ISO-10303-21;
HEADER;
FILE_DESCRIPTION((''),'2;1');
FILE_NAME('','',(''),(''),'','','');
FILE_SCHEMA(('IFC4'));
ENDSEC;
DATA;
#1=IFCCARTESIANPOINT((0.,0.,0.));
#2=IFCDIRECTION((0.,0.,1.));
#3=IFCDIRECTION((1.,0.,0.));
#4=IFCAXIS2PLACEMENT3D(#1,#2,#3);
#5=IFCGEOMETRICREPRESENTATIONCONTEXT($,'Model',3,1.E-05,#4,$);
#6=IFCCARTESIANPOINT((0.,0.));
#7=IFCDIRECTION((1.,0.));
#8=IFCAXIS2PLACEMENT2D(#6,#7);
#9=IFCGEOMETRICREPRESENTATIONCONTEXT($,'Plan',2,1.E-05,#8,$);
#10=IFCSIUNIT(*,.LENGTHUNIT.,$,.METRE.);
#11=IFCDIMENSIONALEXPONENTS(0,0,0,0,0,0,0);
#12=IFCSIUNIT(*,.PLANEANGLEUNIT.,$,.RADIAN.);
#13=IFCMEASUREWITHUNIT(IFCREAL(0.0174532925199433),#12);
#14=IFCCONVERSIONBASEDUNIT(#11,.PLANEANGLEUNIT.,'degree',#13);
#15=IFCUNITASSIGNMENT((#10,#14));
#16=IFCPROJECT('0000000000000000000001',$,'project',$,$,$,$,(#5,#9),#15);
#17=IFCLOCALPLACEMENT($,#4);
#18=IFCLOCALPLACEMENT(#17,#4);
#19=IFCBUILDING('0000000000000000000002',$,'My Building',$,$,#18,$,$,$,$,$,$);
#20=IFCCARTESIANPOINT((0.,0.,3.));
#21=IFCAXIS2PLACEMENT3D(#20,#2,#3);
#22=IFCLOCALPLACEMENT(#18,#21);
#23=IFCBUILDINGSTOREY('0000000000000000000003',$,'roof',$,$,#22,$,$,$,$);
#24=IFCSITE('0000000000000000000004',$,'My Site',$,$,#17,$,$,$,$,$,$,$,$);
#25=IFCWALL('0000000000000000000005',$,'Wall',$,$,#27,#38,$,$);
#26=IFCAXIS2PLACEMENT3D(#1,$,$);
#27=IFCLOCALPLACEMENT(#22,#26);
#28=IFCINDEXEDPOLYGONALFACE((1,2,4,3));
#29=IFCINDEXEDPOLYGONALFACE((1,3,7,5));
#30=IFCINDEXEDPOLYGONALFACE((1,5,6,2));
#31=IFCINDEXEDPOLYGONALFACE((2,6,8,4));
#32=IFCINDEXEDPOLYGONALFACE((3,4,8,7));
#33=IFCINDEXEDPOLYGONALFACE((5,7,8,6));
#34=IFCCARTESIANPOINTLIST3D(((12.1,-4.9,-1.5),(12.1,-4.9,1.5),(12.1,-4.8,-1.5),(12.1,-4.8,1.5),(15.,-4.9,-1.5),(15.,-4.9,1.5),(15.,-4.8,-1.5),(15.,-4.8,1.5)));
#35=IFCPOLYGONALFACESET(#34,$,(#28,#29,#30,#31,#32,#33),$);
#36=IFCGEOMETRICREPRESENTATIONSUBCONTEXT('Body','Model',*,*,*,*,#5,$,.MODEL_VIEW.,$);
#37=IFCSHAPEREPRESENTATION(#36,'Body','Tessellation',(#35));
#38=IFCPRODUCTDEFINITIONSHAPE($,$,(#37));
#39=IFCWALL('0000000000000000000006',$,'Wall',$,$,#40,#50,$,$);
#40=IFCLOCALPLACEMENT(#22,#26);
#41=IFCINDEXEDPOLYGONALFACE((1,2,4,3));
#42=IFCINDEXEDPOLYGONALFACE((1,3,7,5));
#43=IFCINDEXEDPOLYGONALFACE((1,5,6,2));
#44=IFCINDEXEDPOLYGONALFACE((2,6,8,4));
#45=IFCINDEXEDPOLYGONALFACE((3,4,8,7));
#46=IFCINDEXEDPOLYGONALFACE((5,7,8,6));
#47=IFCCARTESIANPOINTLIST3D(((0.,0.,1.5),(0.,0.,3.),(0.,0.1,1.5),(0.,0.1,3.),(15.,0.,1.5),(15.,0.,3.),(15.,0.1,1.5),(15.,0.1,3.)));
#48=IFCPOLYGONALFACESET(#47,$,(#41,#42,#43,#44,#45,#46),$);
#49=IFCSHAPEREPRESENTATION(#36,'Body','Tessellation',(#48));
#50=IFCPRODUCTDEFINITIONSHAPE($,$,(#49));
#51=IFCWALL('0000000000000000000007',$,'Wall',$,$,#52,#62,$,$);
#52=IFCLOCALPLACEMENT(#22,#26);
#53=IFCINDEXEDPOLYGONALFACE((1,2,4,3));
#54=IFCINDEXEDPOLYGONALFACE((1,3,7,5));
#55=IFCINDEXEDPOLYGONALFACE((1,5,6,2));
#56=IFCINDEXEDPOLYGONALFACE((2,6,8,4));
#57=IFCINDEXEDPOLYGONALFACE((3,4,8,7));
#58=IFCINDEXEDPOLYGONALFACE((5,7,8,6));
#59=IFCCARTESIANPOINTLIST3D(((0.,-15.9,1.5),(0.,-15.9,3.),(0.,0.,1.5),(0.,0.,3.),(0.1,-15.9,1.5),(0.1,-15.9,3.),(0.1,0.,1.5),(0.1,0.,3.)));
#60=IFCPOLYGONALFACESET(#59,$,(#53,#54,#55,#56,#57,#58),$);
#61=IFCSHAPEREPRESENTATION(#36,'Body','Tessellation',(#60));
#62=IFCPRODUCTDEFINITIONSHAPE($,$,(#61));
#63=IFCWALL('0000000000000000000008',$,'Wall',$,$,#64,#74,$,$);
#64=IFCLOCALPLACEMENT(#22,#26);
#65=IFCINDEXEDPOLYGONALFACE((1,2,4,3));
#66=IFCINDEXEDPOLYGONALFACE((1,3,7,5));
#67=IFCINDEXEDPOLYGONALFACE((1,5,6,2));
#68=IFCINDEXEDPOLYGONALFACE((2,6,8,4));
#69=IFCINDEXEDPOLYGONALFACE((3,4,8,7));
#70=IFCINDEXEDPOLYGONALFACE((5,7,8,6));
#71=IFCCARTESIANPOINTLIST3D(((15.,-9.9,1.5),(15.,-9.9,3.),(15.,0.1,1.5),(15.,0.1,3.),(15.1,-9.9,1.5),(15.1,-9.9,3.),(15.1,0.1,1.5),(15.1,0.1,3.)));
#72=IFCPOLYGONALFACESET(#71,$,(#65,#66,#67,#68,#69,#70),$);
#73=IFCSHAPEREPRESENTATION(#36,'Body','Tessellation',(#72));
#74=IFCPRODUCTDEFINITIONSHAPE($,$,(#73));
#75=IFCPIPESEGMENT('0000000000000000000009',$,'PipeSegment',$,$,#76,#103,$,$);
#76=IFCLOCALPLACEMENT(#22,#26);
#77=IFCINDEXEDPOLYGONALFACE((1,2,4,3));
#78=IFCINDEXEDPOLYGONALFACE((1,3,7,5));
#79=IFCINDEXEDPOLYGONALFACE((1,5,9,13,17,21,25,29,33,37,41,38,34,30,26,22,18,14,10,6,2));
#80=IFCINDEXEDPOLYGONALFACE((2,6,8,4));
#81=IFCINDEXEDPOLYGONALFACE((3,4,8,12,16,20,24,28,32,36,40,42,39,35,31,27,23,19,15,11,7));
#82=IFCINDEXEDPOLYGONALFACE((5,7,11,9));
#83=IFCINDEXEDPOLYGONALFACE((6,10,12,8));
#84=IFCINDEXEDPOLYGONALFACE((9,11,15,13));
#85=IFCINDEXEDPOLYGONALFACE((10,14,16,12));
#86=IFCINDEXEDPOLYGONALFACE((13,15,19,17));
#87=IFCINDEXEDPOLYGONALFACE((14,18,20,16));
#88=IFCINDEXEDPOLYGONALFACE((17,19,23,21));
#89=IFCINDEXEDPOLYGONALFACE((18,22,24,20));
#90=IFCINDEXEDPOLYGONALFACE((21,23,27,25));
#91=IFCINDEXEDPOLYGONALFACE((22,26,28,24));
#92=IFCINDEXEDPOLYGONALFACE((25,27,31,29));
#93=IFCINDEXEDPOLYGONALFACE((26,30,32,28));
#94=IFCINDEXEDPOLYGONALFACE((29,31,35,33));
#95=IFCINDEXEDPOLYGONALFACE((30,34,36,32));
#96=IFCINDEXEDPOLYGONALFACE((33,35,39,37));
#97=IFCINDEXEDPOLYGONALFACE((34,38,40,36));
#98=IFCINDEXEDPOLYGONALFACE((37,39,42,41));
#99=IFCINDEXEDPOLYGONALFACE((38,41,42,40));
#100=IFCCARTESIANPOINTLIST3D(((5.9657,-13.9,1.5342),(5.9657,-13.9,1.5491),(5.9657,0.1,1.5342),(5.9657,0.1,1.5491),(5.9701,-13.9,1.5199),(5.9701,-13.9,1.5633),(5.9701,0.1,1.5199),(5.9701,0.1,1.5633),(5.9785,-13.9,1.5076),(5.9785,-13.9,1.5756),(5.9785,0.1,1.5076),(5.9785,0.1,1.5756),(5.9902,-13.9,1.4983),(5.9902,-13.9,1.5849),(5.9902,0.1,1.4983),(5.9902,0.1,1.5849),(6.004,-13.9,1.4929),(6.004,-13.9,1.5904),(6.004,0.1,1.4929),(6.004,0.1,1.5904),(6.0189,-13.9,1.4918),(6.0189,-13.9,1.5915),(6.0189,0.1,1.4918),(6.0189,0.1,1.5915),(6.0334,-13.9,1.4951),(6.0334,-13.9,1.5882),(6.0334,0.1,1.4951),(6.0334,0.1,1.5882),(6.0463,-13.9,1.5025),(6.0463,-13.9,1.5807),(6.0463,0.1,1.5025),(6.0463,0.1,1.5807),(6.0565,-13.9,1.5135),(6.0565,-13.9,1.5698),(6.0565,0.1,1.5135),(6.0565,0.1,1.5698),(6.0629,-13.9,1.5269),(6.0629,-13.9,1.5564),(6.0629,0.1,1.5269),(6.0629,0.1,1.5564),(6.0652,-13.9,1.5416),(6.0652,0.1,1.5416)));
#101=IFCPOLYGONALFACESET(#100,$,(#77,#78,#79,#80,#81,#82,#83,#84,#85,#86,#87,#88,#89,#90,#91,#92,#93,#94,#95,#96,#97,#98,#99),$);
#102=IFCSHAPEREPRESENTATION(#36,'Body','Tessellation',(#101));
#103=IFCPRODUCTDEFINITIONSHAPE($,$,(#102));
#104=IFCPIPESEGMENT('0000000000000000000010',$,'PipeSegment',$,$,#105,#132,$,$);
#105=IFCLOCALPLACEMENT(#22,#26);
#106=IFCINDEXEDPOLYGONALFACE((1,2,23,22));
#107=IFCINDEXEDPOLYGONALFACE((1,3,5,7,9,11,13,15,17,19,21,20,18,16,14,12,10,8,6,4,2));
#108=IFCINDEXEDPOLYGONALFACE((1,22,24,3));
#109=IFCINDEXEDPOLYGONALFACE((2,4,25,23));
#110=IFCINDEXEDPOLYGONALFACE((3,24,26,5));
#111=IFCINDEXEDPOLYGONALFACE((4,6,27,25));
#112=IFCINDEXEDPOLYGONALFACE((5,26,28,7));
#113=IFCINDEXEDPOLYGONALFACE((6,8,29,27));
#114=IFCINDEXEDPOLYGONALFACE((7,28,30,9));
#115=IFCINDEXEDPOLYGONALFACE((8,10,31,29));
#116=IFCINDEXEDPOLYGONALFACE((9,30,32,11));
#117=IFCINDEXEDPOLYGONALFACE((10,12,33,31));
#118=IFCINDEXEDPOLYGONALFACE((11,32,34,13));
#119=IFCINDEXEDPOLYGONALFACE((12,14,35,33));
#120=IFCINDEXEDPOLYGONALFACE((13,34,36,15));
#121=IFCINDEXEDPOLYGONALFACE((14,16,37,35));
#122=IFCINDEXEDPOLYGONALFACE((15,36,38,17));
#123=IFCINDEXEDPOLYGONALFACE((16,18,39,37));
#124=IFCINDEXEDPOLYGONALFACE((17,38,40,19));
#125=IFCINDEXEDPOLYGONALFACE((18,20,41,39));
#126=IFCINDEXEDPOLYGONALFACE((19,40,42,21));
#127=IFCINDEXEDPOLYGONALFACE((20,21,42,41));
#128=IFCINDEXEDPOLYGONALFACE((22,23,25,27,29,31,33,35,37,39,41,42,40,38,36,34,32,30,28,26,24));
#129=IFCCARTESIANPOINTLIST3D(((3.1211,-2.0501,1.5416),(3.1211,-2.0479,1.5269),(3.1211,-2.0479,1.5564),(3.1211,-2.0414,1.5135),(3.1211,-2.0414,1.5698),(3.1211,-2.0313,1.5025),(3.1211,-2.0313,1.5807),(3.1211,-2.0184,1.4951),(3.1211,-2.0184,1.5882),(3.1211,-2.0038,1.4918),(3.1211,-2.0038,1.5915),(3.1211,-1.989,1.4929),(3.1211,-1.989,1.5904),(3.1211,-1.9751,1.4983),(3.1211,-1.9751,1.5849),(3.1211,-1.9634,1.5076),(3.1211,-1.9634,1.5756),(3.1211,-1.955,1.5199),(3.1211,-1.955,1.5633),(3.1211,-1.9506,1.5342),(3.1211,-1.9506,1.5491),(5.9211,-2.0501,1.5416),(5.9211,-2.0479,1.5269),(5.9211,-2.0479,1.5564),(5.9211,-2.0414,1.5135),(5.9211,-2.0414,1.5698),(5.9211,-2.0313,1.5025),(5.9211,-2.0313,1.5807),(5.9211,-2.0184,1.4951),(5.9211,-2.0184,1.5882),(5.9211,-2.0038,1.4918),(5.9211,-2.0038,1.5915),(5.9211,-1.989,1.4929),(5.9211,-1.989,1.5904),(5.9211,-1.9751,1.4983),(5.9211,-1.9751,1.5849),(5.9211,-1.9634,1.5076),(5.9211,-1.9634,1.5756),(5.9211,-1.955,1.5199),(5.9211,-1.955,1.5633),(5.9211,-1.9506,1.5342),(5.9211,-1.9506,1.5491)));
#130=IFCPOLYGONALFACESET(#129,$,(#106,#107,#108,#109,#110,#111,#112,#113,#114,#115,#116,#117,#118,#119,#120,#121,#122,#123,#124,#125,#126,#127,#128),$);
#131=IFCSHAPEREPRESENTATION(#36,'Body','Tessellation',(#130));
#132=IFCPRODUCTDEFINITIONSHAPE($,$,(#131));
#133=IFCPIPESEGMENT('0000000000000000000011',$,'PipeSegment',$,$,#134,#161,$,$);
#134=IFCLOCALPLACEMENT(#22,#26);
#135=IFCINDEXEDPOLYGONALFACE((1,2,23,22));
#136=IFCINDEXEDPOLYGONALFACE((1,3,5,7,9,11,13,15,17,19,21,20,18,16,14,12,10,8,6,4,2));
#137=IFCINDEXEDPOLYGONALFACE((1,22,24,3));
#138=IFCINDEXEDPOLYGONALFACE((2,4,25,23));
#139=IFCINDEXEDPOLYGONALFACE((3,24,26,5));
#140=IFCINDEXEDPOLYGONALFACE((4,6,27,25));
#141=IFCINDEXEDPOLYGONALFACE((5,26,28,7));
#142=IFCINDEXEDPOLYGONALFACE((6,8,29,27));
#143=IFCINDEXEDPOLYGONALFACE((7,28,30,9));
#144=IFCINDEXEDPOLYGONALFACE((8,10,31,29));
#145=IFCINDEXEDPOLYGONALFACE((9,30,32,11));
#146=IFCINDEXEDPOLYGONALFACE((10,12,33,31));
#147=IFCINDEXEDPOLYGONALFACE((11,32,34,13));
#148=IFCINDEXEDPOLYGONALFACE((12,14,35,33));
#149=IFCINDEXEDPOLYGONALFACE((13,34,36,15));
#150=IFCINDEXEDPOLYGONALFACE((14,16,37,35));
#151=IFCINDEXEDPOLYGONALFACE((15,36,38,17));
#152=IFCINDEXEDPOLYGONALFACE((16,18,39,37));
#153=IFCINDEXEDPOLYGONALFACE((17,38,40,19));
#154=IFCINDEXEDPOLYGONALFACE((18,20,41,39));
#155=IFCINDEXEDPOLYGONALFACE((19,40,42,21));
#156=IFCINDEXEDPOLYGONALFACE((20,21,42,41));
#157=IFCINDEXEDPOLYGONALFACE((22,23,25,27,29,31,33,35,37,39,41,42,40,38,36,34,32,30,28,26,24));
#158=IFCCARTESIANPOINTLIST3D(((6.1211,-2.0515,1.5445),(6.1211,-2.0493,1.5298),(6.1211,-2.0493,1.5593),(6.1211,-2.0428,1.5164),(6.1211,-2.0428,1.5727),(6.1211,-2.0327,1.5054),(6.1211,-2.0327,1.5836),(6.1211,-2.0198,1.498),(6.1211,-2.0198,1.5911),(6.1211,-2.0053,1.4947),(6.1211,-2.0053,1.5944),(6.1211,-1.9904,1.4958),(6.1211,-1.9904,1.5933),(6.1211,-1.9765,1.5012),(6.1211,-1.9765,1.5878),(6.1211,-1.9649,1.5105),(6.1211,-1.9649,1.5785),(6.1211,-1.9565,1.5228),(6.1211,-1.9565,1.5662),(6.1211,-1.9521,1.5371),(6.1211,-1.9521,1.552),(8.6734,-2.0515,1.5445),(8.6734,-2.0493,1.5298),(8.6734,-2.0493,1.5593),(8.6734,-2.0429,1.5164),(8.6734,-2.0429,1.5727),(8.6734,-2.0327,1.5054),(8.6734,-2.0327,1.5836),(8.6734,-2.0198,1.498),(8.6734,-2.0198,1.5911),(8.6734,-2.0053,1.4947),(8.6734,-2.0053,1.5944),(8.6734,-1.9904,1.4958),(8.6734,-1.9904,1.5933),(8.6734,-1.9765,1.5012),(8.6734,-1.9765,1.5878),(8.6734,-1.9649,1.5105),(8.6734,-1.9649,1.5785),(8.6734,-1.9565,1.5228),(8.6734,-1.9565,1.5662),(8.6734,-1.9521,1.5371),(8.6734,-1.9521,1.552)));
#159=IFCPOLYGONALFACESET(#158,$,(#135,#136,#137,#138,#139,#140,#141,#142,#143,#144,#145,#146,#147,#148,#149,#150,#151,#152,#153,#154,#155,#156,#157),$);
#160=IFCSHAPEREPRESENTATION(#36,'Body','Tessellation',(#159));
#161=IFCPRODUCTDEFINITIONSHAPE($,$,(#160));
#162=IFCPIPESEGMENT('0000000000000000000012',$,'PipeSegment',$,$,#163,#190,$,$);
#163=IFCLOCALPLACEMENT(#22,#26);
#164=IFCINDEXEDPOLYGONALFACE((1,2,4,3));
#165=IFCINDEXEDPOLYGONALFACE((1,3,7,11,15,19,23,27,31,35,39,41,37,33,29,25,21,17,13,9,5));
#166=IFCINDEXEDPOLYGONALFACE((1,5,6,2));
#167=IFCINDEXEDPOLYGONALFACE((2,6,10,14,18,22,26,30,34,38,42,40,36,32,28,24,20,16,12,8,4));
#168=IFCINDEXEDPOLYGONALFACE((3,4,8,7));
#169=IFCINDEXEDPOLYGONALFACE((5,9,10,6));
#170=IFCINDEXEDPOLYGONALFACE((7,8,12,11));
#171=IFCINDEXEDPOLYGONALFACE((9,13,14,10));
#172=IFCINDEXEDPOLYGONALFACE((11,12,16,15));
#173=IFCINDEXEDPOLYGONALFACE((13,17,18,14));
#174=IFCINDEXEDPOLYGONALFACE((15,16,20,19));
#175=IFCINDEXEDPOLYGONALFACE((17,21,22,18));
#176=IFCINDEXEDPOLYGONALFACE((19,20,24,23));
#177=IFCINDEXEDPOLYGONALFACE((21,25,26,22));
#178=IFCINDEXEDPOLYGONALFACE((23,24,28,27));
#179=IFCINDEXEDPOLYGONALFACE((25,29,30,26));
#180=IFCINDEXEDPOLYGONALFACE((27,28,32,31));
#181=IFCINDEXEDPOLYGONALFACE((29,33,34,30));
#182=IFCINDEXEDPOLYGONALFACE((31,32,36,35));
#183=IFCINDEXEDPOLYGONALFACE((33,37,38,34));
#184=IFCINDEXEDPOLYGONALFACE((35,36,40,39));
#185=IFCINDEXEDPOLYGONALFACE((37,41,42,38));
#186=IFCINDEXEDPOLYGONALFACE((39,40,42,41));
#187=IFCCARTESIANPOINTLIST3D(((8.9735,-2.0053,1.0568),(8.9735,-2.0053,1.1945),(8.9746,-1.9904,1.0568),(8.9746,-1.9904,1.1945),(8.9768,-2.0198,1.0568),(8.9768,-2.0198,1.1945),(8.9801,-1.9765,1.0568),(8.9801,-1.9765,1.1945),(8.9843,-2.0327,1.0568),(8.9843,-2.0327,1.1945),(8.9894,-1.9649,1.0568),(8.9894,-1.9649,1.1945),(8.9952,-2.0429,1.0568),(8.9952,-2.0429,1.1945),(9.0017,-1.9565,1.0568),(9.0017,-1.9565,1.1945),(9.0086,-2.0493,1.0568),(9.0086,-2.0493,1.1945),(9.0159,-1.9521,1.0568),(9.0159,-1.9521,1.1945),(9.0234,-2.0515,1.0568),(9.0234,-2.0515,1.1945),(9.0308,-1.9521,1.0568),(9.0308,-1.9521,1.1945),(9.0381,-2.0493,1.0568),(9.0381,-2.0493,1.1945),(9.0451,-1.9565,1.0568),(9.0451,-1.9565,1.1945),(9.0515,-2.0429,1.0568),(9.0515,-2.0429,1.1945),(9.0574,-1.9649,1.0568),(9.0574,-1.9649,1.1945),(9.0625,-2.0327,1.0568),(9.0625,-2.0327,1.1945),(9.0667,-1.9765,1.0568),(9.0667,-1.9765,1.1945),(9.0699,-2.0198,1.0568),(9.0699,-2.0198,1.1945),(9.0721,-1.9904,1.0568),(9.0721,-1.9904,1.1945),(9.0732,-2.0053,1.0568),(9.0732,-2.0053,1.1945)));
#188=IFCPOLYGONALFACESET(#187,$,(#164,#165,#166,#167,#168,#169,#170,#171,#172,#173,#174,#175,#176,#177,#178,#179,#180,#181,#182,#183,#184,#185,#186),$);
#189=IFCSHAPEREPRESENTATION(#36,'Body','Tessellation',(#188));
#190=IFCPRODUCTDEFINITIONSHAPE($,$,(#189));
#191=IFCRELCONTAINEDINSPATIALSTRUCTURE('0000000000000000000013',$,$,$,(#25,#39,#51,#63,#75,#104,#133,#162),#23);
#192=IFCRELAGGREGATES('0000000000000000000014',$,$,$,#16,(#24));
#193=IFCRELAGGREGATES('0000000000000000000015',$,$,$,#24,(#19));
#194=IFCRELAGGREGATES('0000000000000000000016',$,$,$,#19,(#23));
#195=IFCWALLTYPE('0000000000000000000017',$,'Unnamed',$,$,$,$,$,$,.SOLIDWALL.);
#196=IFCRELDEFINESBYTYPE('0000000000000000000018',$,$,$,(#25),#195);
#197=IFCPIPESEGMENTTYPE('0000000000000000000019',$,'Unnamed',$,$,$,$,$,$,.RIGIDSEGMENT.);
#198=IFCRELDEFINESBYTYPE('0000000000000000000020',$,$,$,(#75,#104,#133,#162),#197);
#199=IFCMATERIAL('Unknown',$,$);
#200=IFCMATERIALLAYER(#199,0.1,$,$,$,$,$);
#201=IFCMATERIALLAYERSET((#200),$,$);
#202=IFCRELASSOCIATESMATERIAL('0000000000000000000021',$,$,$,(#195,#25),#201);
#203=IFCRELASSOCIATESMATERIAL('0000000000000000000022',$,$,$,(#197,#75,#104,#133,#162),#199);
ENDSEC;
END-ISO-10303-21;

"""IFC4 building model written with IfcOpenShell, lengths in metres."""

from ifc_helpers import new_model, entity, si_unit, converted_unit, frame, origin_with_axes, origin_2d_with_axis, place, context, subcontext, project, spatial, line, indexed_curve, circle, outline, extrude, material, layer, layer_set, layer_usage, material_profile, profile_set, profile_usage, type_object, element, save


model = new_model("IFC4")

# Units and contexts
model_context = context("Model", 3, precision=1e-05, world=origin_with_axes())
plan_context = context("Plan", 2, precision=1e-05, world=origin_2d_with_axis())
body_context = subcontext(model_context, "Body", "Model", "MODEL_VIEW")
ifc_project = project(units=[si_unit("LENGTHUNIT", "METRE"), converted_unit("PLANEANGLEUNIT", "degree", entity("IfcReal", 0.0174532925199433), si_unit("PLANEANGLEUNIT", "RADIAN"), dimensions=[0, 0, 0, 0, 0, 0, 0])], contexts=[model_context, plan_context])

# Site, building, storey
site_placement = place(None, origin_with_axes())
site = spatial("IfcSite", under=ifc_project, at=site_placement, Name="My Site")
building_placement = place(site_placement, origin_with_axes())
building = spatial("IfcBuilding", under=site, at=building_placement, Name="My Building")
storey_placement = place(building_placement, frame((0.0, 0.0, 3.0), z_axis=(0.0, 0.0, 1.0), x_axis=(1.0, 0.0, 0.0)))
storey = spatial("IfcBuildingStorey", under=building, at=storey_placement, Name="roof")

# Walls
ifc_material = material(Name="Unknown")
ifc_layer = layer(ifc_material, 0.1)
ifc_layer_set = layer_set([ifc_layer])
ifc_layer_usage = layer_usage(ifc_layer_set, "AXIS2", "POSITIVE", 0.0)
wall_type = type_object("IfcWallType", Name="Unnamed", PredefinedType="SOLIDWALL", material=ifc_layer_set)
wall_1_placement = place(storey_placement, frame((12.1, -4.9, -1.5), z_axis=(0.0, 0.0, 1.0), x_axis=(1.0, 0.0, 0.0)))
element("IfcWall", 1, at=wall_1_placement, inside=storey, type_object=wall_type, material=ifc_layer_usage, Name="Wall", context=body_context, shape_type="SweptSolid", body=[
    extrude(outline(indexed_curve([(0.0, 0.0), (0.0, 0.1), (2.9, 0.1), (2.9, 0.0)], segments=[line(1, 2, 3, 4, 1)])), origin_with_axes(), (0.0, 0.0, 1.0), 3.0),
])
wall_2_placement = place(storey_placement, frame((0.0, 0.0, 1.5), z_axis=(0.0, 0.0, 1.0), x_axis=(1.0, 0.0, 0.0)))
element("IfcWall", 2, at=wall_2_placement, inside=storey, Name="Wall", context=body_context, shape_type="SweptSolid", body=[
    extrude(outline(indexed_curve([(0.0, 0.0), (0.0, 0.1), (15.0, 0.1), (15.0, 0.0)], segments=[line(1, 2, 3, 4, 1)])), origin_with_axes(), (0.0, 0.0, 1.0), 1.5),
])
wall_3_placement = place(storey_placement, frame((0.0, 0.0, 1.5), z_axis=(0.0, 0.0, 1.0), x_axis=(0.0, -1.0, 0.0)))
element("IfcWall", 3, at=wall_3_placement, inside=storey, Name="Wall", context=body_context, shape_type="SweptSolid", body=[
    extrude(outline(indexed_curve([(0.0, 0.0), (0.0, 0.1), (15.9, 0.1), (15.9, 0.0)], segments=[line(1, 2, 3, 4, 1)])), origin_with_axes(), (0.0, 0.0, 1.0), 1.5),
])
wall_4_placement = place(storey_placement, frame((15.0, 0.1, 1.5), z_axis=(0.0, 0.0, 1.0), x_axis=(0.0, -1.0, 0.0)))
element("IfcWall", 4, at=wall_4_placement, inside=storey, Name="Wall", context=body_context, shape_type="SweptSolid", body=[
    extrude(outline(indexed_curve([(0.0, 0.0), (0.0, 0.1), (10.0, 0.1), (10.0, 0.0)], segments=[line(1, 2, 3, 4, 1)])), origin_with_axes(), (0.0, 0.0, 1.0), 1.5),
])

# Pipe segments
ifc_material_profile_1 = material_profile(ifc_material, circle(Radius=0.05))
ifc_profile_set_1 = profile_set([ifc_material_profile_1])
ifc_profile_usage_1 = profile_usage(ifc_profile_set_1, cardinal=5)
pipe_segment_type = type_object("IfcPipeSegmentType", Name="Unnamed", PredefinedType="RIGIDSEGMENT", material=ifc_profile_set_1)
pipe_segment_1_placement = place(storey_placement, frame((6.0152, 0.1, 1.5416), z_axis=(0.0, -1.0, 0.0), x_axis=(1.0, 0.0, 0.0)))
element("IfcPipeSegment", 5, at=pipe_segment_1_placement, inside=storey, type_object=pipe_segment_type, material=ifc_profile_usage_1, Name="PipeSegment", context=body_context, shape_type="SweptSolid", body=[
    extrude(circle(Radius=0.05), origin_with_axes(), (0.0, 0.0, 1.0), 14.0),
])
ifc_profile_usage_2 = profile_usage(ifc_profile_set_1, cardinal=5)
pipe_segment_2_placement = place(storey_placement, frame((5.9211, -2.0001, 1.5416), z_axis=(-1.0, 0.0, 0.0), x_axis=(0.0, -1.0, 0.0)))
element("IfcPipeSegment", 6, at=pipe_segment_2_placement, inside=storey, type_object=pipe_segment_type, material=ifc_profile_usage_2, Name="PipeSegment", context=body_context, shape_type="SweptSolid", body=[
    extrude(circle(Radius=0.05), origin_with_axes(), (0.0, 0.0, 1.0), 2.8),
])
ifc_profile_usage_3 = profile_usage(ifc_profile_set_1, cardinal=5)
pipe_segment_3_placement = place(storey_placement, frame((6.1211, -2.0015, 1.5445), z_axis=(1.0, 0.0, 0.0), x_axis=(0.0, -1.0, 0.0)))
element("IfcPipeSegment", 7, at=pipe_segment_3_placement, inside=storey, type_object=pipe_segment_type, material=ifc_profile_usage_3, Name="PipeSegment", context=body_context, shape_type="SweptSolid", body=[
    extrude(circle(Radius=0.05), origin_with_axes(), (0.0, 0.0, 1.0), 2.5523),
])
ifc_profile_usage_4 = profile_usage(ifc_profile_set_1, cardinal=5)
pipe_segment_4_placement = place(storey_placement, frame((9.0234, -2.0015, 1.0568), z_axis=(0.000001, -0.000001, 1.0), x_axis=(0.0, -1.0, -0.000001)))
element("IfcPipeSegment", 8, at=pipe_segment_4_placement, inside=storey, type_object=pipe_segment_type, material=ifc_profile_usage_4, Name="PipeSegment", context=body_context, shape_type="SweptSolid", body=[
    extrude(circle(Radius=0.05), origin_with_axes(), (0.0, 0.0, 1.0), 0.1377),
])

save(model, "model.ifc")
